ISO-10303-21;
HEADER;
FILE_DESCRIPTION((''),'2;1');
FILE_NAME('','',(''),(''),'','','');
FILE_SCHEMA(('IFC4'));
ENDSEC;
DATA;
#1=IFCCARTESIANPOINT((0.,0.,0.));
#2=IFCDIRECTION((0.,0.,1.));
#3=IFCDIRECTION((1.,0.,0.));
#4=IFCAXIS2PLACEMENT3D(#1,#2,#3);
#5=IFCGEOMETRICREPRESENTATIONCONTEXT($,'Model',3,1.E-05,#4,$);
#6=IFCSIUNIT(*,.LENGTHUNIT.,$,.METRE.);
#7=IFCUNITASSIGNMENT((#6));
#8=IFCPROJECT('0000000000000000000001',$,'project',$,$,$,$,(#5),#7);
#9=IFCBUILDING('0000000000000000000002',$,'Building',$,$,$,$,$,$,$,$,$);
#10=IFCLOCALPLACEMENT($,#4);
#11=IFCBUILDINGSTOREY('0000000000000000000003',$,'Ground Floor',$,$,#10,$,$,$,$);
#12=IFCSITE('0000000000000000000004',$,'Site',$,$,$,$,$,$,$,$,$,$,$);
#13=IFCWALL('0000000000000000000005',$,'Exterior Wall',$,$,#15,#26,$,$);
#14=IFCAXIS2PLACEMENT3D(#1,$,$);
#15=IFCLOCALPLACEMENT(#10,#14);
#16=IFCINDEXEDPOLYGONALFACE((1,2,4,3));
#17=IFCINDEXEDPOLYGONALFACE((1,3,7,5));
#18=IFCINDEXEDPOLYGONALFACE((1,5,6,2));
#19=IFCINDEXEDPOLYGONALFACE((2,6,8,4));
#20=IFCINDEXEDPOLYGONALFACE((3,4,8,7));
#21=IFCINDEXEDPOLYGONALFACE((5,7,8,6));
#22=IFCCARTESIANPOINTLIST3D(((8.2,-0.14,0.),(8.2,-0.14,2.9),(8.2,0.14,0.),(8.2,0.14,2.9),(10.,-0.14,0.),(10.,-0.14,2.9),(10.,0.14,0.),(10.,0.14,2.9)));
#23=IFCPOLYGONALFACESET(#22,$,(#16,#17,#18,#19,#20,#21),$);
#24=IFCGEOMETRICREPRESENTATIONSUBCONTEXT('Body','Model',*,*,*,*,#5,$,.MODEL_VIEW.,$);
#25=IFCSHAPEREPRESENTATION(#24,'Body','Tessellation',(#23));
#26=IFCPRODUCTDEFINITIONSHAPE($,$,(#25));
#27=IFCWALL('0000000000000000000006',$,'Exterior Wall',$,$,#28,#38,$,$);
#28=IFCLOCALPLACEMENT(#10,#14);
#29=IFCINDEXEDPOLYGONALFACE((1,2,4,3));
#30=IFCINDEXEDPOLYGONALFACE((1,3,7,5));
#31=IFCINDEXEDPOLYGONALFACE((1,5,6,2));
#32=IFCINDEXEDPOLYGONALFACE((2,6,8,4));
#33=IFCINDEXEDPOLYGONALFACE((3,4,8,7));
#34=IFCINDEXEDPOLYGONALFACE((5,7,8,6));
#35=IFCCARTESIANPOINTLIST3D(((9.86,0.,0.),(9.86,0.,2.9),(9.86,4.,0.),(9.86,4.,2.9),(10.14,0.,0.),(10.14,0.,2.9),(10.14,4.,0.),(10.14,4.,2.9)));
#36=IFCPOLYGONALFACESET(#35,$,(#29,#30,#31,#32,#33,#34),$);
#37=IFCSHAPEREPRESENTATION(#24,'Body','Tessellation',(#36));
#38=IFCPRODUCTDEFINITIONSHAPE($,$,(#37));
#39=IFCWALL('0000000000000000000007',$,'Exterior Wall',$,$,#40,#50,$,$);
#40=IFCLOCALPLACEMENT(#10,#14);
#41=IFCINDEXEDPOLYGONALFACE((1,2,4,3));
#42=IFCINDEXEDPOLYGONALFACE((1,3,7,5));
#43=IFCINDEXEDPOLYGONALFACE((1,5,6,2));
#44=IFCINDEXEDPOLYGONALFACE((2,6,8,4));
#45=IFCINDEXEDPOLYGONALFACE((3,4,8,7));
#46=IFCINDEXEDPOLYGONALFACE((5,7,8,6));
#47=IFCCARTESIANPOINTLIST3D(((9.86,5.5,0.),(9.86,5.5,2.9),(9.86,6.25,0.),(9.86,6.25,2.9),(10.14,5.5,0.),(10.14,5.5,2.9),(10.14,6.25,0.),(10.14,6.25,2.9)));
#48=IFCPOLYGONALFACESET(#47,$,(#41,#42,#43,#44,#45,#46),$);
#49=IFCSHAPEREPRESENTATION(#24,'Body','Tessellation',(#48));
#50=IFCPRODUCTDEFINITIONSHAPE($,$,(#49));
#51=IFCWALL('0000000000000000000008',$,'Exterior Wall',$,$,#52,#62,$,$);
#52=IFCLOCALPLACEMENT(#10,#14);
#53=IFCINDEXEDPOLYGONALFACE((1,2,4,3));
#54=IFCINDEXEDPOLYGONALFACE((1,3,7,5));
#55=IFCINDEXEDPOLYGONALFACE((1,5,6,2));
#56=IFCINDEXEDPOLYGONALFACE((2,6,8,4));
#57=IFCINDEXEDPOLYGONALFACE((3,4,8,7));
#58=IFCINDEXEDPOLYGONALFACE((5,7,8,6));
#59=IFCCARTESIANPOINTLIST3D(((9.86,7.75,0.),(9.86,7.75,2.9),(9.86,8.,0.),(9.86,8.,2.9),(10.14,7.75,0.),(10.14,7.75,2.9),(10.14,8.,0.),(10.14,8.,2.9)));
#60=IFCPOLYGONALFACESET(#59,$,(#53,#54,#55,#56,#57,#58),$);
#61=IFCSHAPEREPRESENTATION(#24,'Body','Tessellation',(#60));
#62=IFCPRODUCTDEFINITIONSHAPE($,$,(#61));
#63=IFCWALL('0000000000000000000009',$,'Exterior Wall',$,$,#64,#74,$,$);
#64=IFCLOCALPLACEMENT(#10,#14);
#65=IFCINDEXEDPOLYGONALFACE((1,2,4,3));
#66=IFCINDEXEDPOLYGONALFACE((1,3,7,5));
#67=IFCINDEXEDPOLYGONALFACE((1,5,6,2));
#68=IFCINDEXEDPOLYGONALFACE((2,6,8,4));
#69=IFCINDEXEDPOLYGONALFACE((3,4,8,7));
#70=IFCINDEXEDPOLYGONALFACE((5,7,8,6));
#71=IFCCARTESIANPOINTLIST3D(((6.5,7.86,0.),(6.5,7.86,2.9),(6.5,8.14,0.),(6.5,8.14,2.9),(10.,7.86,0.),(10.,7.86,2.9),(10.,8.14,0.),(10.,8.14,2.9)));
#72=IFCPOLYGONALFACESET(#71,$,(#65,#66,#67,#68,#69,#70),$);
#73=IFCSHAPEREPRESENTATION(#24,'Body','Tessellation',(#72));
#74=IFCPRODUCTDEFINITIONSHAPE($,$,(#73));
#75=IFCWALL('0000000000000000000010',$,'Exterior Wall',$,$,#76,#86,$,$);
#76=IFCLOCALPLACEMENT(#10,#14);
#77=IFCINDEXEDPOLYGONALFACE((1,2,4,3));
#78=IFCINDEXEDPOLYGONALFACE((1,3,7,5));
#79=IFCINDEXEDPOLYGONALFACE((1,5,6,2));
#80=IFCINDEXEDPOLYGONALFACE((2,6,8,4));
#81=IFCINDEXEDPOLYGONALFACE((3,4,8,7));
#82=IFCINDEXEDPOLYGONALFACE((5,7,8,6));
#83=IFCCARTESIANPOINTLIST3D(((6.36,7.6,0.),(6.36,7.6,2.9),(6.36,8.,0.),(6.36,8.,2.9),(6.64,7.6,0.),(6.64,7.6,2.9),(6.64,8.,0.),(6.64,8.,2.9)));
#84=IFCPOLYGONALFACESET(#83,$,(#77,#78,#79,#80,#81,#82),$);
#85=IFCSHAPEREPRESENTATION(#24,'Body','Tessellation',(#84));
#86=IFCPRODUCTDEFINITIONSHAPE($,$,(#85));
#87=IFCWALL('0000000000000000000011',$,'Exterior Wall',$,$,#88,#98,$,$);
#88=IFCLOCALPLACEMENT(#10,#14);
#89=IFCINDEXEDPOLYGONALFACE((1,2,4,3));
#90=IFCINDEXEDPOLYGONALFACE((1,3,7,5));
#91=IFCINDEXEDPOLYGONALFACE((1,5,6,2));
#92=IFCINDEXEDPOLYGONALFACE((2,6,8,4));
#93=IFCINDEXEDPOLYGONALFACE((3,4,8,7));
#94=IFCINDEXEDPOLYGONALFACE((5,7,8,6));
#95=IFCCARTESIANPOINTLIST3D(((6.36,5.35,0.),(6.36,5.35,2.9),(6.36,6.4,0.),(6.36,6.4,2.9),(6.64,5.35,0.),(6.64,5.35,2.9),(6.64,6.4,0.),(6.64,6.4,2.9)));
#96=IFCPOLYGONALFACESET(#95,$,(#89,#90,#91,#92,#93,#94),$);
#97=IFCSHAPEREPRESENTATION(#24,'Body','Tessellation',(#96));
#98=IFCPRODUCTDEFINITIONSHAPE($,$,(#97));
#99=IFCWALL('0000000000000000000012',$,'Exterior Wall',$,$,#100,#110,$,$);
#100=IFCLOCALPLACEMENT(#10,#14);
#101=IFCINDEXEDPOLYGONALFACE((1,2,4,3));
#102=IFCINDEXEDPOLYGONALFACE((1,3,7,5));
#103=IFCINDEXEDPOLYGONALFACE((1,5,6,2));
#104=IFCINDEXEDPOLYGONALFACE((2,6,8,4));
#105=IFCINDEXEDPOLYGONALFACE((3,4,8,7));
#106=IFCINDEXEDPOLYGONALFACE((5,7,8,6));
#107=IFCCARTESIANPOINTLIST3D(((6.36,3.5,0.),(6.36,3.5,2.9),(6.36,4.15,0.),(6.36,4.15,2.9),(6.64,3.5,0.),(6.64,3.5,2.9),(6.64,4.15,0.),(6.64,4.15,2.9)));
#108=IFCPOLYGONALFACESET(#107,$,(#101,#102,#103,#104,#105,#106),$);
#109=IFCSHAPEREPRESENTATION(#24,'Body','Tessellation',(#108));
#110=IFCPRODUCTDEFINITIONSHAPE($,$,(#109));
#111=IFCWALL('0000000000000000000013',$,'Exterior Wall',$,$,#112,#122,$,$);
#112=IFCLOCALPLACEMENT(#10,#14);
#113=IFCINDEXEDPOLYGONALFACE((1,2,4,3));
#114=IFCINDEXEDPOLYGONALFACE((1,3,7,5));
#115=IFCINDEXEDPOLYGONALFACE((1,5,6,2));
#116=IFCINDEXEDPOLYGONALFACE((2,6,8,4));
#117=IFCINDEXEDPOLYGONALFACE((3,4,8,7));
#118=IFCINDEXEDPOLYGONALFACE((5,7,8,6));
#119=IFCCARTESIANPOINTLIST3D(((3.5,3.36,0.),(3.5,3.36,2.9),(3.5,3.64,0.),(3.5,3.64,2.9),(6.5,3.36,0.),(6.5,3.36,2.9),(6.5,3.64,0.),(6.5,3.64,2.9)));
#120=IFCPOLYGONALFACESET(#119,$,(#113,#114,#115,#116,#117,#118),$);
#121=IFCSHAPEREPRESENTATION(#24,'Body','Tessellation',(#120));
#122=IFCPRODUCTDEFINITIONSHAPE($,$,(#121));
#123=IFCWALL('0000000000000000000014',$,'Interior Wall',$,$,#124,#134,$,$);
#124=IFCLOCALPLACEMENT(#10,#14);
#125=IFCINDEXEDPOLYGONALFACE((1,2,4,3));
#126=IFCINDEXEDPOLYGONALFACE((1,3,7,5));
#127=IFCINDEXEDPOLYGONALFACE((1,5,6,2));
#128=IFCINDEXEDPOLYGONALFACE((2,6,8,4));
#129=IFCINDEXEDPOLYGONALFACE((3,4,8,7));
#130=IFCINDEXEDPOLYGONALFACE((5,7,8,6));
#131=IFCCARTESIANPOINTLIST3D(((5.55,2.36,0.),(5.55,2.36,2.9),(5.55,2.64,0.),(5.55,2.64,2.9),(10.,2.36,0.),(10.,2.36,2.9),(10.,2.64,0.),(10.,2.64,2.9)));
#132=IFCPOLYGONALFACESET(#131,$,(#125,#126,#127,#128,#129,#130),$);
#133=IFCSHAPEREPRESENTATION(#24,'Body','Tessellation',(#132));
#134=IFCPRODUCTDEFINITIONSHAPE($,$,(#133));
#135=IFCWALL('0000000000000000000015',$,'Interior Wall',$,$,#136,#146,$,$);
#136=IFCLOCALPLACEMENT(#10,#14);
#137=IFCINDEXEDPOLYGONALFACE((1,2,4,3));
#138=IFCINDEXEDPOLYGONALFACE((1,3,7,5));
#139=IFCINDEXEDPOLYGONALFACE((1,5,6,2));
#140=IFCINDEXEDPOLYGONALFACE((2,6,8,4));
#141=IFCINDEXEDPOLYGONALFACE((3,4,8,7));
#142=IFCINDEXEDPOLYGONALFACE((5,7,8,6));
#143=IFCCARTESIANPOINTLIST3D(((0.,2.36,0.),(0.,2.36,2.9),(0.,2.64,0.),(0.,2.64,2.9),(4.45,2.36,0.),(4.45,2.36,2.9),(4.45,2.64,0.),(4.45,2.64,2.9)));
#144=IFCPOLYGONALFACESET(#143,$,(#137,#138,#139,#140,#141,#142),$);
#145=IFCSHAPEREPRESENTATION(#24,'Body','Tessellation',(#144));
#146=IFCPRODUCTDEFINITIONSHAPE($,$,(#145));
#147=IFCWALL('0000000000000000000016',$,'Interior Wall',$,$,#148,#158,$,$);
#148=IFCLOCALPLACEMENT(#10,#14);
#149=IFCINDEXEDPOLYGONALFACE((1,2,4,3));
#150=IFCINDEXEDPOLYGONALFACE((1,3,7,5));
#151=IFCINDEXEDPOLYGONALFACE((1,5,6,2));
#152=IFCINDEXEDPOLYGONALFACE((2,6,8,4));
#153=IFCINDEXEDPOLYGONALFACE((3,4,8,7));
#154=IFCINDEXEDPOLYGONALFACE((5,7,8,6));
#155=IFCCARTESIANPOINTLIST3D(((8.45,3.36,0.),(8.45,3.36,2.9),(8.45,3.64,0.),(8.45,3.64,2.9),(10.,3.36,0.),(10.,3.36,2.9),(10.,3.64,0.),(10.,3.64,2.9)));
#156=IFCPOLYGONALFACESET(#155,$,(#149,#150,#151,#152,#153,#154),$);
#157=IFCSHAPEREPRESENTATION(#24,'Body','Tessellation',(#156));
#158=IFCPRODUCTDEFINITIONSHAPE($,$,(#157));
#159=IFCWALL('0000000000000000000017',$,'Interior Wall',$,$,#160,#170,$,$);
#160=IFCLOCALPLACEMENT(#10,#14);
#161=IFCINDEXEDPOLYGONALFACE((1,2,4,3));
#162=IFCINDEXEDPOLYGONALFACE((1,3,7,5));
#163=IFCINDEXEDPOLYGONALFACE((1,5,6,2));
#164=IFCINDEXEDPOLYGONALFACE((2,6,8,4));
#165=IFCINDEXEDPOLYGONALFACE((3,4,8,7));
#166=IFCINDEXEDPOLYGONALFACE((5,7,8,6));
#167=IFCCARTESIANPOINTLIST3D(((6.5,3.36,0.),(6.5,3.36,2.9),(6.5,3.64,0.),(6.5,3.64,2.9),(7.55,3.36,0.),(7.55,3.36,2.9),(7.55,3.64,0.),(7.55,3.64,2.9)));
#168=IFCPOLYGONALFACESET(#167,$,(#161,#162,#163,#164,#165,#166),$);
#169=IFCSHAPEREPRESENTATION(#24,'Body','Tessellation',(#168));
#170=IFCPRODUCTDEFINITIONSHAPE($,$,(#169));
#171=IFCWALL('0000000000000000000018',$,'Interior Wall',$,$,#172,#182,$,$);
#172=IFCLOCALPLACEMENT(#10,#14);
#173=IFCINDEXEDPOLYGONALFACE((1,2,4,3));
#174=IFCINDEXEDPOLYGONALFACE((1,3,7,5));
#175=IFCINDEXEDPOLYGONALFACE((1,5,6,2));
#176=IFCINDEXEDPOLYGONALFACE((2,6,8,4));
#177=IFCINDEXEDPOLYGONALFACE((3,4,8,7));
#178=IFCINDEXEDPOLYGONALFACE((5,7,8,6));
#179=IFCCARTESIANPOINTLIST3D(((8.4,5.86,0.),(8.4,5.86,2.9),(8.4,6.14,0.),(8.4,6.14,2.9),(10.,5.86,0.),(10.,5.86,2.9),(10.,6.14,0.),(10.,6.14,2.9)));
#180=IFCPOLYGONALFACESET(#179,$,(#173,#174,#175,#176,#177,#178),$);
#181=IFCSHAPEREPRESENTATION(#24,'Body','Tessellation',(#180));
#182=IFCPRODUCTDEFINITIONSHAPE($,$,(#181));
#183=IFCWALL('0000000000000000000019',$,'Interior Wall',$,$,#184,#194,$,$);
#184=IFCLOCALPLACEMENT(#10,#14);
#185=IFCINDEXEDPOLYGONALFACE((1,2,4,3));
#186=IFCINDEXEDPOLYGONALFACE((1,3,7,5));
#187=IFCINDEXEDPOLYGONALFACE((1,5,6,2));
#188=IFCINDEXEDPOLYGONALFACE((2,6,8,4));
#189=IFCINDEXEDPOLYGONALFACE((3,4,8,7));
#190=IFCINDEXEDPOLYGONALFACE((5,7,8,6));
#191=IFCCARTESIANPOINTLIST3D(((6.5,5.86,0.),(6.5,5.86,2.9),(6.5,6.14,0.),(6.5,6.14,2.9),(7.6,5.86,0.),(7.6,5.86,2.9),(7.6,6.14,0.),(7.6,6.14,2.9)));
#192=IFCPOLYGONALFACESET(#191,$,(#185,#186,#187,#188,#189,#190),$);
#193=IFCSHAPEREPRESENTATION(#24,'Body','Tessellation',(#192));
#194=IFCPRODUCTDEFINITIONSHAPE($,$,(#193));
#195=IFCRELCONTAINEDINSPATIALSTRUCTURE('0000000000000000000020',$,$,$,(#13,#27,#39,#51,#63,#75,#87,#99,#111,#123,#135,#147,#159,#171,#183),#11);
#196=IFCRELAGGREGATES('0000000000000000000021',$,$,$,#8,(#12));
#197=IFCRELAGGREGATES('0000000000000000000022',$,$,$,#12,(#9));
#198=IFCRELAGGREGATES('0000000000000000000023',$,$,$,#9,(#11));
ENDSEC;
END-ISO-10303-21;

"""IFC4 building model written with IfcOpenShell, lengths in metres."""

from ifc_helpers import new_model, si_unit, frame, origin_with_axes, place, context, subcontext, project, spatial, indexed_curve, outline, extrude, element, save


model = new_model("IFC4")

# Units and contexts
model_context = context("Model", 3, precision=1e-05, world=origin_with_axes())
body_context = subcontext(model_context, "Body", "Model", "MODEL_VIEW")
ifc_project = project(units=[si_unit("LENGTHUNIT", "METRE")], contexts=[model_context])

# Site, building, storey
site = spatial("IfcSite", under=ifc_project, Name="Site")
building = spatial("IfcBuilding", under=site, Name="Building")
storey_placement = place(None, origin_with_axes())
storey = spatial("IfcBuildingStorey", under=building, at=storey_placement, Name="Ground Floor")

# Walls
wall_1_placement = place(storey_placement, frame((8.2, 0.0, 0.0), z_axis=(0.0, 0.0, 1.0), x_axis=(1.0, 0.0, 0.0)))
element("IfcWall", 1, at=wall_1_placement, inside=storey, Name="Exterior Wall", context=body_context, shape_type="SweptSolid", body=[
    extrude(outline(indexed_curve([(0.0, 0.0), (0.0, 0.28), (1.8, 0.28), (1.8, 0.0), (0.0, 0.0)], self_intersect=False)), frame((0.0, -0.14, 0.0), z_axis=(0.0, 0.0, 1.0), x_axis=(1.0, 0.0, 0.0)), (0.0, 0.0, 1.0), 2.9),
])
wall_2_placement = place(storey_placement, frame((10.0, 0.0, 0.0), z_axis=(0.0, 0.0, 1.0), x_axis=(0.0, 1.0, 0.0)))
element("IfcWall", 2, at=wall_2_placement, inside=storey, Name="Exterior Wall", context=body_context, shape_type="SweptSolid", body=[
    extrude(outline(indexed_curve([(0.0, 0.0), (0.0, 0.28), (4.0, 0.28), (4.0, 0.0), (0.0, 0.0)], self_intersect=False)), frame((0.0, -0.14, 0.0), z_axis=(0.0, 0.0, 1.0), x_axis=(1.0, 0.0, 0.0)), (0.0, 0.0, 1.0), 2.9),
])
wall_3_placement = place(storey_placement, frame((10.0, 5.5, 0.0), z_axis=(0.0, 0.0, 1.0), x_axis=(0.0, 1.0, 0.0)))
element("IfcWall", 3, at=wall_3_placement, inside=storey, Name="Exterior Wall", context=body_context, shape_type="SweptSolid", body=[
    extrude(outline(indexed_curve([(0.0, 0.0), (0.0, 0.28), (0.75, 0.28), (0.75, 0.0), (0.0, 0.0)], self_intersect=False)), frame((0.0, -0.14, 0.0), z_axis=(0.0, 0.0, 1.0), x_axis=(1.0, 0.0, 0.0)), (0.0, 0.0, 1.0), 2.9),
])
wall_4_placement = place(storey_placement, frame((10.0, 7.75, 0.0), z_axis=(0.0, 0.0, 1.0), x_axis=(0.0, 1.0, 0.0)))
element("IfcWall", 4, at=wall_4_placement, inside=storey, Name="Exterior Wall", context=body_context, shape_type="SweptSolid", body=[
    extrude(outline(indexed_curve([(0.0, 0.0), (0.0, 0.28), (0.25, 0.28), (0.25, 0.0), (0.0, 0.0)], self_intersect=False)), frame((0.0, -0.14, 0.0), z_axis=(0.0, 0.0, 1.0), x_axis=(1.0, 0.0, 0.0)), (0.0, 0.0, 1.0), 2.9),
])
wall_5_placement = place(storey_placement, frame((10.0, 8.0, 0.0), z_axis=(0.0, 0.0, 1.0), x_axis=(-1.0, 0.0, 0.0)))
element("IfcWall", 5, at=wall_5_placement, inside=storey, Name="Exterior Wall", context=body_context, shape_type="SweptSolid", body=[
    extrude(outline(indexed_curve([(0.0, 0.0), (0.0, 0.28), (3.5, 0.28), (3.5, 0.0), (0.0, 0.0)], self_intersect=False)), frame((0.0, -0.14, 0.0), z_axis=(0.0, 0.0, 1.0), x_axis=(1.0, 0.0, 0.0)), (0.0, 0.0, 1.0), 2.9),
])
wall_6_placement = place(storey_placement, frame((6.5, 8.0, 0.0), z_axis=(0.0, 0.0, 1.0), x_axis=(0.0, -1.0, 0.0)))
element("IfcWall", 6, at=wall_6_placement, inside=storey, Name="Exterior Wall", context=body_context, shape_type="SweptSolid", body=[
    extrude(outline(indexed_curve([(0.0, 0.0), (0.0, 0.28), (0.4, 0.28), (0.4, 0.0), (0.0, 0.0)], self_intersect=False)), frame((0.0, -0.14, 0.0), z_axis=(0.0, 0.0, 1.0), x_axis=(1.0, 0.0, 0.0)), (0.0, 0.0, 1.0), 2.9),
])
wall_7_placement = place(storey_placement, frame((6.5, 6.4, 0.0), z_axis=(0.0, 0.0, 1.0), x_axis=(0.0, -1.0, 0.0)))
element("IfcWall", 7, at=wall_7_placement, inside=storey, Name="Exterior Wall", context=body_context, shape_type="SweptSolid", body=[
    extrude(outline(indexed_curve([(0.0, 0.0), (0.0, 0.28), (1.05, 0.28), (1.05, 0.0), (0.0, 0.0)], self_intersect=False)), frame((0.0, -0.14, 0.0), z_axis=(0.0, 0.0, 1.0), x_axis=(1.0, 0.0, 0.0)), (0.0, 0.0, 1.0), 2.9),
])
wall_8_placement = place(storey_placement, frame((6.5, 4.15, 0.0), z_axis=(0.0, 0.0, 1.0), x_axis=(0.0, -1.0, 0.0)))
element("IfcWall", 8, at=wall_8_placement, inside=storey, Name="Exterior Wall", context=body_context, shape_type="SweptSolid", body=[
    extrude(outline(indexed_curve([(0.0, 0.0), (0.0, 0.28), (0.65, 0.28), (0.65, 0.0), (0.0, 0.0)], self_intersect=False)), frame((0.0, -0.14, 0.0), z_axis=(0.0, 0.0, 1.0), x_axis=(1.0, 0.0, 0.0)), (0.0, 0.0, 1.0), 2.9),
])
wall_9_placement = place(storey_placement, frame((6.5, 3.5, 0.0), z_axis=(0.0, 0.0, 1.0), x_axis=(-1.0, 0.0, 0.0)))
element("IfcWall", 9, at=wall_9_placement, inside=storey, Name="Exterior Wall", context=body_context, shape_type="SweptSolid", body=[
    extrude(outline(indexed_curve([(0.0, 0.0), (0.0, 0.28), (3.0, 0.28), (3.0, 0.0), (0.0, 0.0)], self_intersect=False)), frame((0.0, -0.14, 0.0), z_axis=(0.0, 0.0, 1.0), x_axis=(1.0, 0.0, 0.0)), (0.0, 0.0, 1.0), 2.9),
])
for number, where, z_axis, x_axis, name in (
    (10, (10.0, 2.5, 0.0), (0.0, 0.0, 1.0), (-1.0, 0.0, 0.0), "Interior Wall"),
    (11, (4.45, 2.5, 0.0), (0.0, 0.0, 1.0), (-1.0, 0.0, 0.0), "Interior Wall"),
):
    element("IfcWall", number, at=place(storey_placement, frame(where, z_axis=z_axis, x_axis=x_axis)), inside=storey, Name=name, context=body_context, shape_type="SweptSolid", body=[
        extrude(outline(indexed_curve([(0.0, 0.0), (0.0, 0.28), (4.45, 0.28), (4.45, 0.0), (0.0, 0.0)], self_intersect=False)), frame((0.0, -0.14, 0.0), z_axis=(0.0, 0.0, 1.0), x_axis=(1.0, 0.0, 0.0)), (0.0, 0.0, 1.0), 2.9),
    ])
wall_10_placement = place(storey_placement, frame((10.0, 3.5, 0.0), z_axis=(0.0, 0.0, 1.0), x_axis=(-1.0, 0.0, 0.0)))
element("IfcWall", 12, at=wall_10_placement, inside=storey, Name="Interior Wall", context=body_context, shape_type="SweptSolid", body=[
    extrude(outline(indexed_curve([(0.0, 0.0), (0.0, 0.28), (1.55, 0.28), (1.55, 0.0), (0.0, 0.0)], self_intersect=False)), frame((0.0, -0.14, 0.0), z_axis=(0.0, 0.0, 1.0), x_axis=(1.0, 0.0, 0.0)), (0.0, 0.0, 1.0), 2.9),
])
wall_11_placement = place(storey_placement, frame((7.55, 3.5, 0.0), z_axis=(0.0, 0.0, 1.0), x_axis=(-1.0, 0.0, 0.0)))
element("IfcWall", 13, at=wall_11_placement, inside=storey, Name="Interior Wall", context=body_context, shape_type="SweptSolid", body=[
    extrude(outline(indexed_curve([(0.0, 0.0), (0.0, 0.28), (1.05, 0.28), (1.05, 0.0), (0.0, 0.0)], self_intersect=False)), frame((0.0, -0.14, 0.0), z_axis=(0.0, 0.0, 1.0), x_axis=(1.0, 0.0, 0.0)), (0.0, 0.0, 1.0), 2.9),
])
wall_12_placement = place(storey_placement, frame((10.0, 6.0, 0.0), z_axis=(0.0, 0.0, 1.0), x_axis=(-1.0, 0.0, 0.0)))
element("IfcWall", 14, at=wall_12_placement, inside=storey, Name="Interior Wall", context=body_context, shape_type="SweptSolid", body=[
    extrude(outline(indexed_curve([(0.0, 0.0), (0.0, 0.28), (1.6, 0.28), (1.6, 0.0), (0.0, 0.0)], self_intersect=False)), frame((0.0, -0.14, 0.0), z_axis=(0.0, 0.0, 1.0), x_axis=(1.0, 0.0, 0.0)), (0.0, 0.0, 1.0), 2.9),
])
wall_13_placement = place(storey_placement, frame((7.6, 6.0, 0.0), z_axis=(0.0, 0.0, 1.0), x_axis=(-1.0, 0.0, 0.0)))
element("IfcWall", 15, at=wall_13_placement, inside=storey, Name="Interior Wall", context=body_context, shape_type="SweptSolid", body=[
    extrude(outline(indexed_curve([(0.0, 0.0), (0.0, 0.28), (1.1, 0.28), (1.1, 0.0), (0.0, 0.0)], self_intersect=False)), frame((0.0, -0.14, 0.0), z_axis=(0.0, 0.0, 1.0), x_axis=(1.0, 0.0, 0.0)), (0.0, 0.0, 1.0), 2.9),
])

save(model, "model.ifc")
